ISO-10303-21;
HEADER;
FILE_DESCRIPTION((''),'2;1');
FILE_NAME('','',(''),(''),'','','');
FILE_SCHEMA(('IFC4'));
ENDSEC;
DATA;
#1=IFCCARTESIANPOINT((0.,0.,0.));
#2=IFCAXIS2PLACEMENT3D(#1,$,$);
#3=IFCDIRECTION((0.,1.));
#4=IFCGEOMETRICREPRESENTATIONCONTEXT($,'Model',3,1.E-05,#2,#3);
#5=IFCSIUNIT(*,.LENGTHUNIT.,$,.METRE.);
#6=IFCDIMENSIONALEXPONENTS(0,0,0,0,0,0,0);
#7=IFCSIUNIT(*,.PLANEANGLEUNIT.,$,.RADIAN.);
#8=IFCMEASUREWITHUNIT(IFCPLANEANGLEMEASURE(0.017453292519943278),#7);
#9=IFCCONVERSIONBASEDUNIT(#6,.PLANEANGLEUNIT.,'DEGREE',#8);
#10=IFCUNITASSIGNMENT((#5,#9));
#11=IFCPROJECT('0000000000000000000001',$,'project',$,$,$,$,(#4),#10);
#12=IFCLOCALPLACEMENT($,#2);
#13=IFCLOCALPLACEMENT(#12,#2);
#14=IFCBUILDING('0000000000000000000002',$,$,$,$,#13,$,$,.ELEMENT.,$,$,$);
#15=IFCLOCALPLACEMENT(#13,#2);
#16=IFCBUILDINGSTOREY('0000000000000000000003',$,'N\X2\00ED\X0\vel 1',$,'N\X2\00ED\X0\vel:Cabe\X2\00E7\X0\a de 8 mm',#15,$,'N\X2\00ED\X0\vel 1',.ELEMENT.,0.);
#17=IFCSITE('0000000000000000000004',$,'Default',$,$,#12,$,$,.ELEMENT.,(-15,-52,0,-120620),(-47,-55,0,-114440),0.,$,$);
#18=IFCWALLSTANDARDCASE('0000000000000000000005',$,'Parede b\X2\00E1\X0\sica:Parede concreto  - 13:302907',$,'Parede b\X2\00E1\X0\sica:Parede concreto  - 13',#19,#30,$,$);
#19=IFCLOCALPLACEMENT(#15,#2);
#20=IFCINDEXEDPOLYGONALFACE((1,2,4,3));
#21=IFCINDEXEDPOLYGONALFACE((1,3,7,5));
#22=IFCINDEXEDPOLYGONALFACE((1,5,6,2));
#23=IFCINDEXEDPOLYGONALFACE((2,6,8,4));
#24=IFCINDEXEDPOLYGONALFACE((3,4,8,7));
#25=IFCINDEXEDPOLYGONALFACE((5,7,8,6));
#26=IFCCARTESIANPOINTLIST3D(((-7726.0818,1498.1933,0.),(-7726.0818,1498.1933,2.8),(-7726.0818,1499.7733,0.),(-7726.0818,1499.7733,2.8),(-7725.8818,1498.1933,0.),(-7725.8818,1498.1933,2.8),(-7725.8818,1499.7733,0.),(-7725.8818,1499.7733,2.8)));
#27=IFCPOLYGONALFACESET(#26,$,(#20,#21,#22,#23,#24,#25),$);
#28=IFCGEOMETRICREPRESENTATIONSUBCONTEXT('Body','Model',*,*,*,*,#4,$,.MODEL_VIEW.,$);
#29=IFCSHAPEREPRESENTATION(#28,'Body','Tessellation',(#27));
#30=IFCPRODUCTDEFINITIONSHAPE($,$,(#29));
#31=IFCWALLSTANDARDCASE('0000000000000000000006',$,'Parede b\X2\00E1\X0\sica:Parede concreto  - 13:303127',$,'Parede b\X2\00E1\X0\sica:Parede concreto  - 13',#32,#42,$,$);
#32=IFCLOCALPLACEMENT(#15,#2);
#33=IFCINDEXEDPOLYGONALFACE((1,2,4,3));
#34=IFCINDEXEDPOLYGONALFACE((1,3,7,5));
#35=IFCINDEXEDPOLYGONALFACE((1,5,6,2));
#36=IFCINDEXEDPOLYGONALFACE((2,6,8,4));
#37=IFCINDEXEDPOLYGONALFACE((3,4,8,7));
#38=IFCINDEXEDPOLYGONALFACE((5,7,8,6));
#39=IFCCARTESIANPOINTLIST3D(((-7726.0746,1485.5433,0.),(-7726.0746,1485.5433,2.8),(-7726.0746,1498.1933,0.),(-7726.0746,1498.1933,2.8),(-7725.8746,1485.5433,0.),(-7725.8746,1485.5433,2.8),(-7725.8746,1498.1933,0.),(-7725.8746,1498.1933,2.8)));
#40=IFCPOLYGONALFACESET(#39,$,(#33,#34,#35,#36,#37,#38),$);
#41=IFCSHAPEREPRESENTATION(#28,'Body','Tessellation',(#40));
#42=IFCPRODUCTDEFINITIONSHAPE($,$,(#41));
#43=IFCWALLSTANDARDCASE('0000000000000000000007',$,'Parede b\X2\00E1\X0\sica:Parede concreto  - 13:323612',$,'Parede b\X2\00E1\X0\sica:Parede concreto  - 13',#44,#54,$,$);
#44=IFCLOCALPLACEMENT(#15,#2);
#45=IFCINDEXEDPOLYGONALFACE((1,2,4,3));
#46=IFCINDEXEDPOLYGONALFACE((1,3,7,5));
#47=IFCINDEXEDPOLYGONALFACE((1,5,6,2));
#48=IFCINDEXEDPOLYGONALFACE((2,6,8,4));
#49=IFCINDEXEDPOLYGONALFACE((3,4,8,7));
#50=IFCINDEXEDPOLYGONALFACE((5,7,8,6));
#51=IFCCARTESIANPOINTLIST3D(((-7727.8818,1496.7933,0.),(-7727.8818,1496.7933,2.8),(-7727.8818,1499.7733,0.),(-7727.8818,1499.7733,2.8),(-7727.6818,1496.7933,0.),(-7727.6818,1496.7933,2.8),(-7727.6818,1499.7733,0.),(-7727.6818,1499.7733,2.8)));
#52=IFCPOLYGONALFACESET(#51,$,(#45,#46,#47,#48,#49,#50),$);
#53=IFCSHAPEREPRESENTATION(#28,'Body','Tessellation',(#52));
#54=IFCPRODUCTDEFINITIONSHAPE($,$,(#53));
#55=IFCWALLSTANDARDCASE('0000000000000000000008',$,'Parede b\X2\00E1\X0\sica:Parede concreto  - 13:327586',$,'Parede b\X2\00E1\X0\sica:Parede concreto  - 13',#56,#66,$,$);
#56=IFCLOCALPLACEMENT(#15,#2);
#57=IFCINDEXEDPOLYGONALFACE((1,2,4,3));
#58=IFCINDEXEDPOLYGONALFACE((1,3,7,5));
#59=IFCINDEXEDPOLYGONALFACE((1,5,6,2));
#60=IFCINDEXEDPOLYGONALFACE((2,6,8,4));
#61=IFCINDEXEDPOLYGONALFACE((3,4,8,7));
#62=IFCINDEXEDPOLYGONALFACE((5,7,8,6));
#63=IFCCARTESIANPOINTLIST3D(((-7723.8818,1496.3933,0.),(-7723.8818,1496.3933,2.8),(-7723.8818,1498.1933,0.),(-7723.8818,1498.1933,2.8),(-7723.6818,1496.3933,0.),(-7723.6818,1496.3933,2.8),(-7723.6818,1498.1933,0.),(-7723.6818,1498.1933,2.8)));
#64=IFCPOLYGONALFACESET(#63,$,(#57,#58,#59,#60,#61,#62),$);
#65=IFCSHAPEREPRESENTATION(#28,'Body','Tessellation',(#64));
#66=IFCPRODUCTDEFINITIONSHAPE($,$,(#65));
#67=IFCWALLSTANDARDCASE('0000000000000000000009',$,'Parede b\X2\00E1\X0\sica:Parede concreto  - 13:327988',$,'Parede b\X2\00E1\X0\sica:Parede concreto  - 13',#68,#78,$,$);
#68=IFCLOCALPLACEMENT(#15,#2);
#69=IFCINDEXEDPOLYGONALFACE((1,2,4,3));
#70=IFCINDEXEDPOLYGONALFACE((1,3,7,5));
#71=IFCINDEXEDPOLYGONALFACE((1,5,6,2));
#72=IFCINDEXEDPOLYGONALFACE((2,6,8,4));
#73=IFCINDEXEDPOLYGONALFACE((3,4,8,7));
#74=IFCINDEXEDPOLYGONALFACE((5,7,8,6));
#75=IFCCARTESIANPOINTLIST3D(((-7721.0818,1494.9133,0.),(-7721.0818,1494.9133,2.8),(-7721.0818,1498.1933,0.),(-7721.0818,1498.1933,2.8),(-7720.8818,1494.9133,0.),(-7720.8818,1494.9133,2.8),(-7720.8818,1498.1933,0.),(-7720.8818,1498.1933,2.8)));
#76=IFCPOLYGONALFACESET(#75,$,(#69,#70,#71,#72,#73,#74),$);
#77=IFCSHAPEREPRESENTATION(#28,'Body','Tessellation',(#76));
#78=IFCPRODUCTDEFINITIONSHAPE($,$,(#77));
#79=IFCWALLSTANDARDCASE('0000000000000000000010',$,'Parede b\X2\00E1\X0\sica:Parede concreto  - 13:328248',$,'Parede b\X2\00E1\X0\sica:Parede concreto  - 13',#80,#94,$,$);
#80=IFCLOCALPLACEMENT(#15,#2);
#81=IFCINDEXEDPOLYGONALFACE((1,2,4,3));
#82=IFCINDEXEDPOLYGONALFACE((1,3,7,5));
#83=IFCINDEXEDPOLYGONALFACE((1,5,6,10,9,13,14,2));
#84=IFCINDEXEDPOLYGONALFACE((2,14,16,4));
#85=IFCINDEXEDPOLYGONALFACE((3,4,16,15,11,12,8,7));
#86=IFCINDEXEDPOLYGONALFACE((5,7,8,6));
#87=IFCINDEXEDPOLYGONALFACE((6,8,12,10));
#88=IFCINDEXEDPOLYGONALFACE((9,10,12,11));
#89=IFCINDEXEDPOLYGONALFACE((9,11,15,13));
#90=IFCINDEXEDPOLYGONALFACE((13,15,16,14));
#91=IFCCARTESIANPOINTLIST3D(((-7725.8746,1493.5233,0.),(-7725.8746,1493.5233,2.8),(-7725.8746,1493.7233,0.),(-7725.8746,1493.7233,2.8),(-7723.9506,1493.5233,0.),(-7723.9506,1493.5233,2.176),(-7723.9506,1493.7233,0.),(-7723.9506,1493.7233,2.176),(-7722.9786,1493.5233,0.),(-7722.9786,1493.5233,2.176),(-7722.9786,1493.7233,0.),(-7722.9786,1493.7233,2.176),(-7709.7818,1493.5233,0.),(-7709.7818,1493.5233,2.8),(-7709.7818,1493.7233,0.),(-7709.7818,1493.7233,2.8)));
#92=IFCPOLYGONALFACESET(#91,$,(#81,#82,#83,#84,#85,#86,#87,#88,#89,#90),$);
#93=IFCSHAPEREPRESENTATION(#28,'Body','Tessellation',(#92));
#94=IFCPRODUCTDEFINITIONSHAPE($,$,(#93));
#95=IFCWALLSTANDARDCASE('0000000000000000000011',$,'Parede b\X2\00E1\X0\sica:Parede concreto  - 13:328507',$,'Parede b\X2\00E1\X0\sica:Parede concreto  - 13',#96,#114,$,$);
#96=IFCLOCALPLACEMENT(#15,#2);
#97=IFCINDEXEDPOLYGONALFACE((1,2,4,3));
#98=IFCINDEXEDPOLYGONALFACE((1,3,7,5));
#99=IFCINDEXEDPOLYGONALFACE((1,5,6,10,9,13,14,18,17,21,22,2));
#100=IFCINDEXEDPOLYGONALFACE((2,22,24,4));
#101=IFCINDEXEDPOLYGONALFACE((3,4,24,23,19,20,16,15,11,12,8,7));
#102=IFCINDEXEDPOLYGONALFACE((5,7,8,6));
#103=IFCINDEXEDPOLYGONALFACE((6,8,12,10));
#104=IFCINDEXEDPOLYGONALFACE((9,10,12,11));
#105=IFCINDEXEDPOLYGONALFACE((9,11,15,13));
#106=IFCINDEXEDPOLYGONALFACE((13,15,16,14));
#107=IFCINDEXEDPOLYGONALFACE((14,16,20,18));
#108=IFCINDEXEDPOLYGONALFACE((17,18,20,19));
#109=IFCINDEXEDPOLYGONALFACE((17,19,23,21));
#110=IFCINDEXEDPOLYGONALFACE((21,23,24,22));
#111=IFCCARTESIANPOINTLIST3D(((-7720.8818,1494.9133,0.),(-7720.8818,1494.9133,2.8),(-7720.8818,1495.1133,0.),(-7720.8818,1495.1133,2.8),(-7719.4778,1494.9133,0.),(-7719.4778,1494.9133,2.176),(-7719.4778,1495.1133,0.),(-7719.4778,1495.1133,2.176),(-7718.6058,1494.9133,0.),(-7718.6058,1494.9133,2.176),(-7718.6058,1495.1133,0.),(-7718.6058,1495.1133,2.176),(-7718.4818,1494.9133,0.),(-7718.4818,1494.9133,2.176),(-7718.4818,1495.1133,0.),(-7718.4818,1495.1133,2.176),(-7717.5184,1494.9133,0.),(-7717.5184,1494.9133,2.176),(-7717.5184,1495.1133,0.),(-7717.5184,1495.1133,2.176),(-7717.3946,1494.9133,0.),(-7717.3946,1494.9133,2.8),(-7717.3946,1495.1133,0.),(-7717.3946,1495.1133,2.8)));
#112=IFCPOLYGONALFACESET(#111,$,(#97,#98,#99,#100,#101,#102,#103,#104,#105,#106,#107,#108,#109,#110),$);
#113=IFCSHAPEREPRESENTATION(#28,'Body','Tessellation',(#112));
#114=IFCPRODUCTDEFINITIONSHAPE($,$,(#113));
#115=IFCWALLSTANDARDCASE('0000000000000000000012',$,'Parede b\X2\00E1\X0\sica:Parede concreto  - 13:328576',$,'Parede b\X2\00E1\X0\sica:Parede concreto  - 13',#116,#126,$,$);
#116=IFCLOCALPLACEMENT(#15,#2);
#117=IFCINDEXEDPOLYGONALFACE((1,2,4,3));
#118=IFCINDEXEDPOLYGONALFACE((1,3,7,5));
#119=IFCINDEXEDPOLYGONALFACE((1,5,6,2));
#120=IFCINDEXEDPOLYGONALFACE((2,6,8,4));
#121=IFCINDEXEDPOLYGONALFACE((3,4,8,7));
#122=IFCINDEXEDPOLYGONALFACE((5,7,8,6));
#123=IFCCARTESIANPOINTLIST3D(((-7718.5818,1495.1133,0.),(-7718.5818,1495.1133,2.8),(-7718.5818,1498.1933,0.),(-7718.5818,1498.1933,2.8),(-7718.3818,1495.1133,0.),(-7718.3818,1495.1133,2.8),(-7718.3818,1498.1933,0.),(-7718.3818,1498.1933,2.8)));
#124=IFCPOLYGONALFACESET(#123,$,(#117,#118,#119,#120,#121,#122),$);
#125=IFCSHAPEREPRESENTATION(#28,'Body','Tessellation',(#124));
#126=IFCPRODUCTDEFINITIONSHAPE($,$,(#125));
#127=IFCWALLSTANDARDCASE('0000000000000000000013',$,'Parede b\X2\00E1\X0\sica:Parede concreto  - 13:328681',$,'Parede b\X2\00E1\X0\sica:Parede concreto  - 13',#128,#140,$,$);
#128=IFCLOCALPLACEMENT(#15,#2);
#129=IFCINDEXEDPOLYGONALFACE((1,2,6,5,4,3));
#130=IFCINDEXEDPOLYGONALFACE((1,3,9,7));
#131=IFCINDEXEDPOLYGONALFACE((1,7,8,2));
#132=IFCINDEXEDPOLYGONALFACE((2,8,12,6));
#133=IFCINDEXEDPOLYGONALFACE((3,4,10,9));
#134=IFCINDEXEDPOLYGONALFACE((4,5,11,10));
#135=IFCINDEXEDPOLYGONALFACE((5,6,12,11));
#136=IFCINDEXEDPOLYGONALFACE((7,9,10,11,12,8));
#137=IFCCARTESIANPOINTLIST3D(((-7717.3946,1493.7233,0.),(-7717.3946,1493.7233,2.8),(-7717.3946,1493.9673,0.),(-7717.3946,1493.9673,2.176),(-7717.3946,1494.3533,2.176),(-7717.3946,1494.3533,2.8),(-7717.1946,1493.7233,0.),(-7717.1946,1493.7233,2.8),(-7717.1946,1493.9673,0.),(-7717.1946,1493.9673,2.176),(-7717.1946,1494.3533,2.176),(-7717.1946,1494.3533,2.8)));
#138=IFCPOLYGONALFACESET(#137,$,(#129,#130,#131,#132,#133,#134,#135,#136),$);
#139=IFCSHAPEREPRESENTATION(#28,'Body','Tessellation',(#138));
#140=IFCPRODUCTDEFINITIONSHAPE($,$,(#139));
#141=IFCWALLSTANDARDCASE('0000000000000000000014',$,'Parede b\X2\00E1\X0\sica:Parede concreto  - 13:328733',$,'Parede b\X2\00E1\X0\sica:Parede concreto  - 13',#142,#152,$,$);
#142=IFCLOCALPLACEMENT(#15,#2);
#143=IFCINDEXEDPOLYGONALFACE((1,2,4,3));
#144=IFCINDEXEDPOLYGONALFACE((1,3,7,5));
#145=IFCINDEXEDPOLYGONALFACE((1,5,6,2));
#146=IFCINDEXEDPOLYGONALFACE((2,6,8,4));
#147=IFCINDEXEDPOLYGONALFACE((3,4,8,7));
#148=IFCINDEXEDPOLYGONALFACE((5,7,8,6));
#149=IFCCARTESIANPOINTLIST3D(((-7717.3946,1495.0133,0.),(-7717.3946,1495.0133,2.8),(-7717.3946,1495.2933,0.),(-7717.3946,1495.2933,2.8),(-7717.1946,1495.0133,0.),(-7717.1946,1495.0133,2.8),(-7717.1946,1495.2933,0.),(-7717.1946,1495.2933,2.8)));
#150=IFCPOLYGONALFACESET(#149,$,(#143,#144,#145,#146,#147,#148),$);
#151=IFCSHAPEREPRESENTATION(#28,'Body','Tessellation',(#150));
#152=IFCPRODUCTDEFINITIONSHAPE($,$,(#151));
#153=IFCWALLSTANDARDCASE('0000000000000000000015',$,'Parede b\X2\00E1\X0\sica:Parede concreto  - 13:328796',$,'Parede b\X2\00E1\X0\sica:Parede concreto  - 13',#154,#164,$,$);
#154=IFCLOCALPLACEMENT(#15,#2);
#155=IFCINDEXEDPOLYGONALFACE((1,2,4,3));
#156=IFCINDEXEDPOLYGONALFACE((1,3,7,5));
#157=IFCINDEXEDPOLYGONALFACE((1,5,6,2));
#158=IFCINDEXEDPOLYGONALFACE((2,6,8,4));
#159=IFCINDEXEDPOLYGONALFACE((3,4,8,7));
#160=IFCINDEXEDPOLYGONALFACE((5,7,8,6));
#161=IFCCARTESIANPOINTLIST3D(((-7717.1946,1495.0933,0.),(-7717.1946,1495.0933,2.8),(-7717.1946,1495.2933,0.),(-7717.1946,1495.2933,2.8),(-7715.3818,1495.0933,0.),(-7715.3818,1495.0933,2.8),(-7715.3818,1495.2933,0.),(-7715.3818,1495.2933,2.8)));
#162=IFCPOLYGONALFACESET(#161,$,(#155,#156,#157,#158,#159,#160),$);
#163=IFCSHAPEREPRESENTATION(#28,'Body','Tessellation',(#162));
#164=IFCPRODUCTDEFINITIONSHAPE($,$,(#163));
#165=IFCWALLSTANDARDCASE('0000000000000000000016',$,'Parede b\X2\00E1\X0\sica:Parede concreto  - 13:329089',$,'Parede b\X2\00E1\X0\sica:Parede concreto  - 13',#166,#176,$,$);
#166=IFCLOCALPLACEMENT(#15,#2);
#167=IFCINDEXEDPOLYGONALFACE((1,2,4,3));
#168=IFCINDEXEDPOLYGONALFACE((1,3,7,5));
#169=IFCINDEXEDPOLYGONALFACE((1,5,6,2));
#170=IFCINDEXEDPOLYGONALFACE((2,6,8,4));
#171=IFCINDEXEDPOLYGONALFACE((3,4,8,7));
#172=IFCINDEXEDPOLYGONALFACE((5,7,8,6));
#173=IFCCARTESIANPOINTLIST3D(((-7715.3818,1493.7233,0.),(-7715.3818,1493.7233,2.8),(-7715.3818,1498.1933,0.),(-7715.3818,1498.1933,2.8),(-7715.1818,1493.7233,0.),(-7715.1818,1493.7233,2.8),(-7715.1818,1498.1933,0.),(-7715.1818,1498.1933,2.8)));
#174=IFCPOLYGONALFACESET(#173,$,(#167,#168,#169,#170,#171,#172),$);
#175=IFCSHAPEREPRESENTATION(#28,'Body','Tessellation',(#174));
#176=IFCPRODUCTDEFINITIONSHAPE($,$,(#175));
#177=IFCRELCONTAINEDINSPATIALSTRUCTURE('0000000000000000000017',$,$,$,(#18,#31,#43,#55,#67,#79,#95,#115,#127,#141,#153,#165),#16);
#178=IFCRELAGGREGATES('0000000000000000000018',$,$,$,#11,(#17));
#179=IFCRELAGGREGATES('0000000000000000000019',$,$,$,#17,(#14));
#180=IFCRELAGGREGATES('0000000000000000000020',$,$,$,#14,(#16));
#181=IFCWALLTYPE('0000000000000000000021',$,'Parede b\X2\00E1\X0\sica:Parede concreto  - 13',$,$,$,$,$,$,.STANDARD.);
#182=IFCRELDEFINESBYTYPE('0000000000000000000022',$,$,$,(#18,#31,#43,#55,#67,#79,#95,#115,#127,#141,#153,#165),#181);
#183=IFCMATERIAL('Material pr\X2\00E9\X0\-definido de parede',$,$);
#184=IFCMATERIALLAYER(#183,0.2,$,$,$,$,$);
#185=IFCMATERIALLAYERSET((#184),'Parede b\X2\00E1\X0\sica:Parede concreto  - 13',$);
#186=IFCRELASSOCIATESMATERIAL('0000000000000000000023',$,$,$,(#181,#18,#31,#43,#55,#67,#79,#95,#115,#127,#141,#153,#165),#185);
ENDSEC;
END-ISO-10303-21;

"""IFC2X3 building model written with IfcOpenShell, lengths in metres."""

from ifc_helpers import new_model, entity, si_unit, converted_unit, direction, frame, frame_2d, origin, place, context, subcontext, project, spatial, rectangle, extrude, material, layer, layer_set, layer_usage, type_object, element, save


model = new_model("IFC2X3")

# Units and contexts
model_context = context("Model", 3, precision=1e-05, world=origin(), true_north=direction((0.0, 1.0)))
body_context = subcontext(model_context, "Body", "Model", "MODEL_VIEW")
ifc_project = project(units=[si_unit("LENGTHUNIT", "METRE"), converted_unit("PLANEANGLEUNIT", "DEGREE", entity("IfcPlaneAngleMeasure", 0.017453292519943278), si_unit("PLANEANGLEUNIT", "RADIAN"), dimensions=[0, 0, 0, 0, 0, 0, 0])], contexts=[model_context])

# Site, building, storey
site_placement = place(None, origin())
site = spatial("IfcSite", under=ifc_project, at=site_placement, Name="Default", CompositionType="ELEMENT", RefLatitude=(-15, -52, 0, -120620), RefLongitude=(-47, -55, 0, -114440), RefElevation=0.0)
building_placement = place(site_placement, origin())
building = spatial("IfcBuilding", under=site, at=building_placement, CompositionType="ELEMENT")
storey_placement = place(building_placement, origin())
storey = spatial("IfcBuildingStorey", under=building, at=storey_placement, Name="Nível 1", ObjectType="Nível:Cabeça de 8 mm", LongName="Nível 1", CompositionType="ELEMENT", Elevation=0.0)

# Walls
ifc_material_1 = material(Name="Material pré-definido de parede")
ifc_layer = layer(ifc_material_1, 0.2)
ifc_layer_set = layer_set([ifc_layer], Name="Parede básica:Parede concreto  - 13")
ifc_layer_usage_1 = layer_usage(ifc_layer_set, "AXIS2", "NEGATIVE", 0.1)
wall_type = type_object("IfcWallType", Name="Parede básica:Parede concreto  - 13", PredefinedType="STANDARD", material=ifc_layer_set)
wall_1_placement = place(storey_placement, frame((-7725.9818, 1499.7733, 0.0), z_axis=(0.0, 0.0, 1.0), x_axis=(0.0, -1.0, 0.0)))
element("IfcWallStandardCase", 1, at=wall_1_placement, inside=storey, type_object=wall_type, material=ifc_layer_usage_1, Name="Parede básica:Parede concreto  - 13:302907", ObjectType="Parede básica:Parede concreto  - 13", context=body_context, shape_type="SweptSolid", body=[
    extrude(rectangle(XDim=1.58, YDim=0.2, at=frame_2d((0.79, 0.0), x_axis=(-1.0, 0.0))), origin(), (0.0, 0.0, 1.0), 2.8),
])
ifc_layer_usage_2 = layer_usage(ifc_layer_set, "AXIS2", "NEGATIVE", 0.1)
wall_2_placement = place(storey_placement, frame((-7725.9746, 1498.1933, 0.0), z_axis=(0.0, 0.0, 1.0), x_axis=(0.0, -1.0, 0.0)))
element("IfcWallStandardCase", 2, at=wall_2_placement, inside=storey, type_object=wall_type, material=ifc_layer_usage_2, Name="Parede básica:Parede concreto  - 13:303127", ObjectType="Parede básica:Parede concreto  - 13", context=body_context, shape_type="SweptSolid", body=[
    extrude(rectangle(XDim=12.65, YDim=0.2, at=frame_2d((6.325, 0.0), x_axis=(-1.0, 0.0))), origin(), (0.0, 0.0, 1.0), 2.8),
])

# Walls
ifc_layer_usage_3 = layer_usage(ifc_layer_set, "AXIS2", "POSITIVE", -0.1)
wall_3_placement = place(storey_placement, frame((-7727.7818, 1499.7733, 0.0), z_axis=(0.0, 0.0, 1.0), x_axis=(0.0, -1.0, 0.0)))
element("IfcWallStandardCase", 3, at=wall_3_placement, inside=storey, type_object=wall_type, material=ifc_layer_usage_3, Name="Parede básica:Parede concreto  - 13:323612", ObjectType="Parede básica:Parede concreto  - 13", context=body_context, shape_type="SweptSolid", body=[
    extrude(rectangle(XDim=2.98, YDim=0.2, at=frame_2d((1.49, 0.0), x_axis=(-1.0, 0.0))), origin(), (0.0, 0.0, 1.0), 2.8),
])
ifc_layer_usage_4 = layer_usage(ifc_layer_set, "AXIS2", "NEGATIVE", 0.1)
wall_4_placement = place(storey_placement, frame((-7723.7818, 1498.1933, 0.0), z_axis=(0.0, 0.0, 1.0), x_axis=(0.0, -1.0, 0.0)))
element("IfcWallStandardCase", 4, at=wall_4_placement, inside=storey, type_object=wall_type, material=ifc_layer_usage_4, Name="Parede básica:Parede concreto  - 13:327586", ObjectType="Parede básica:Parede concreto  - 13", context=body_context, shape_type="SweptSolid", body=[
    extrude(rectangle(XDim=1.8, YDim=0.2, at=frame_2d((0.9, 0.0), x_axis=(-1.0, 0.0))), origin(), (0.0, 0.0, 1.0), 2.8),
])
ifc_layer_usage_5 = layer_usage(ifc_layer_set, "AXIS2", "NEGATIVE", 0.1)
wall_5_placement = place(storey_placement, frame((-7720.9818, 1498.1933, 0.0), z_axis=(0.0, 0.0, 1.0), x_axis=(0.0, -1.0, 0.0)))
element("IfcWallStandardCase", 5, at=wall_5_placement, inside=storey, type_object=wall_type, material=ifc_layer_usage_5, Name="Parede básica:Parede concreto  - 13:327988", ObjectType="Parede básica:Parede concreto  - 13", context=body_context, shape_type="SweptSolid", body=[
    extrude(rectangle(XDim=3.28, YDim=0.2, at=frame_2d((1.64, 0.0), x_axis=(-1.0, 0.0))), origin(), (0.0, 0.0, 1.0), 2.8),
])

# Wall, opening
ifc_layer_usage_6 = layer_usage(ifc_layer_set, "AXIS2", "POSITIVE", -0.1)
wall_6_placement = place(storey_placement, frame((-7725.8746, 1493.6233, 0.0)))
wall_6 = element("IfcWallStandardCase", 6, at=wall_6_placement, inside=storey, type_object=wall_type, material=ifc_layer_usage_6, Name="Parede básica:Parede concreto  - 13:328248", ObjectType="Parede básica:Parede concreto  - 13", context=body_context, shape_type="SweptSolid", body=[
    extrude(rectangle(XDim=16.0928, YDim=0.2, at=frame_2d((8.0464, 0.0), x_axis=(-1.0, 0.0))), origin(), (0.0, 0.0, 1.0), 2.8),
])
opening_1_placement = place(wall_6_placement, origin())
element("IfcOpeningElement", 7, at=opening_1_placement, cuts=wall_6, ObjectType="Opening", context=body_context, shape_type="SweptSolid", body=[
    extrude(rectangle(XDim=2.176, YDim=0.972, at=frame_2d((0.0, 0.0), x_axis=(0.0, 1.0))), frame((2.41, 0.1, 1.088), z_axis=(0.0, -1.0, 0.0), x_axis=(1.0, 0.0, 0.0)), (0.0, 0.0, 1.0), 0.2),
])

# Wall, openings
ifc_layer_usage_7 = layer_usage(ifc_layer_set, "AXIS2", "NEGATIVE", 0.1)
wall_7_placement = place(storey_placement, frame((-7720.8818, 1495.0133, 0.0)))
wall_7 = element("IfcWallStandardCase", 8, at=wall_7_placement, inside=storey, type_object=wall_type, material=ifc_layer_usage_7, Name="Parede básica:Parede concreto  - 13:328507", ObjectType="Parede básica:Parede concreto  - 13", context=body_context, shape_type="SweptSolid", body=[
    extrude(rectangle(XDim=3.4872, YDim=0.2, at=frame_2d((1.7436, 0.0), x_axis=(-1.0, 0.0))), origin(), (0.0, 0.0, 1.0), 2.8),
])
opening_2_placement = place(wall_7_placement, origin())
element("IfcOpeningElement", 9, at=opening_2_placement, cuts=wall_7, ObjectType="Opening", context=body_context, shape_type="SweptSolid", body=[
    extrude(rectangle(XDim=2.176, YDim=0.872, at=frame_2d((0.0, 0.0), x_axis=(0.0, 1.0))), frame((1.84, 0.1, 1.088), z_axis=(0.0, -1.0, 0.0), x_axis=(1.0, 0.0, 0.0)), (0.0, 0.0, 1.0), 0.2),
])
opening_3_placement = place(wall_7_placement, origin())
element("IfcOpeningElement", 10, at=opening_3_placement, cuts=wall_7, ObjectType="Opening", context=body_context, shape_type="SweptSolid", body=[
    extrude(rectangle(XDim=2.176, YDim=0.9635, at=frame_2d((0.0, 0.0), x_axis=(0.0, 1.0))), frame((2.8817, 0.1, 1.088), z_axis=(0.0, -1.0, 0.0), x_axis=(1.0, 0.0, 0.0)), (0.0, 0.0, 1.0), 0.2),
])

# Wall
ifc_layer_usage_8 = layer_usage(ifc_layer_set, "AXIS2", "NEGATIVE", 0.1)
wall_8_placement = place(storey_placement, frame((-7718.4818, 1498.1933, 0.0), z_axis=(0.0, 0.0, 1.0), x_axis=(0.0, -1.0, 0.0)))
element("IfcWallStandardCase", 11, at=wall_8_placement, inside=storey, type_object=wall_type, material=ifc_layer_usage_8, Name="Parede básica:Parede concreto  - 13:328576", ObjectType="Parede básica:Parede concreto  - 13", context=body_context, shape_type="SweptSolid", body=[
    extrude(rectangle(XDim=3.08, YDim=0.2, at=frame_2d((1.54, 0.0), x_axis=(-1.0, 0.0))), origin(), (0.0, 0.0, 1.0), 2.8),
])

# Wall, opening
ifc_layer_usage_9 = layer_usage(ifc_layer_set, "AXIS2", "NEGATIVE", 0.1)
wall_9_placement = place(storey_placement, frame((-7717.2946, 1493.7233, 0.0), z_axis=(0.0, 0.0, 1.0), x_axis=(0.0, 1.0, 0.0)))
wall_9 = element("IfcWallStandardCase", 12, at=wall_9_placement, inside=storey, type_object=wall_type, material=ifc_layer_usage_9, Name="Parede básica:Parede concreto  - 13:328681", ObjectType="Parede básica:Parede concreto  - 13", context=body_context, shape_type="SweptSolid", body=[
    extrude(rectangle(XDim=0.63, YDim=0.2, at=frame_2d((0.315, 0.0), x_axis=(-1.0, 0.0))), origin(), (0.0, 0.0, 1.0), 2.8),
])
opening_4_placement = place(wall_9_placement, origin())
element("IfcOpeningElement", 13, at=opening_4_placement, cuts=wall_9, ObjectType="Opening", context=body_context, shape_type="SweptSolid", body=[
    extrude(rectangle(XDim=2.176, YDim=0.386, at=frame_2d((0.0, 0.0), x_axis=(0.0, 1.0))), frame((0.437, 0.1, 1.088), z_axis=(0.0, -1.0, 0.0), x_axis=(1.0, 0.0, 0.0)), (0.0, 0.0, 1.0), 0.2),
])

# Walls
ifc_layer_usage_10 = layer_usage(ifc_layer_set, "AXIS2", "NEGATIVE", 0.1)
wall_10_placement = place(storey_placement, frame((-7717.2946, 1495.0133, 0.0), z_axis=(0.0, 0.0, 1.0), x_axis=(0.0, 1.0, 0.0)))
element("IfcWallStandardCase", 14, at=wall_10_placement, inside=storey, type_object=wall_type, material=ifc_layer_usage_10, Name="Parede básica:Parede concreto  - 13:328733", ObjectType="Parede básica:Parede concreto  - 13", context=body_context, shape_type="SweptSolid", body=[
    extrude(rectangle(XDim=0.28, YDim=0.2, at=frame_2d((0.14, 0.0), x_axis=(-1.0, 0.0))), origin(), (0.0, 0.0, 1.0), 2.8),
])
ifc_layer_usage_11 = layer_usage(ifc_layer_set, "AXIS2", "NEGATIVE", 0.1)
wall_11_placement = place(storey_placement, frame((-7717.1946, 1495.1933, 0.0)))
element("IfcWallStandardCase", 15, at=wall_11_placement, inside=storey, type_object=wall_type, material=ifc_layer_usage_11, Name="Parede básica:Parede concreto  - 13:328796", ObjectType="Parede básica:Parede concreto  - 13", context=body_context, shape_type="SweptSolid", body=[
    extrude(rectangle(XDim=1.8128, YDim=0.2, at=frame_2d((0.9064, 0.0), x_axis=(-1.0, 0.0))), origin(), (0.0, 0.0, 1.0), 2.8),
])
ifc_layer_usage_12 = layer_usage(ifc_layer_set, "AXIS2", "NEGATIVE", 0.1)
wall_12_placement = place(storey_placement, frame((-7715.2818, 1498.1933, 0.0), z_axis=(0.0, 0.0, 1.0), x_axis=(0.0, -1.0, 0.0)))
element("IfcWallStandardCase", 16, at=wall_12_placement, inside=storey, type_object=wall_type, material=ifc_layer_usage_12, Name="Parede básica:Parede concreto  - 13:329089", ObjectType="Parede básica:Parede concreto  - 13", context=body_context, shape_type="SweptSolid", body=[
    extrude(rectangle(XDim=4.47, YDim=0.2, at=frame_2d((2.235, 0.0), x_axis=(-1.0, 0.0))), origin(), (0.0, 0.0, 1.0), 2.8),
])

save(model, "model.ifc")
